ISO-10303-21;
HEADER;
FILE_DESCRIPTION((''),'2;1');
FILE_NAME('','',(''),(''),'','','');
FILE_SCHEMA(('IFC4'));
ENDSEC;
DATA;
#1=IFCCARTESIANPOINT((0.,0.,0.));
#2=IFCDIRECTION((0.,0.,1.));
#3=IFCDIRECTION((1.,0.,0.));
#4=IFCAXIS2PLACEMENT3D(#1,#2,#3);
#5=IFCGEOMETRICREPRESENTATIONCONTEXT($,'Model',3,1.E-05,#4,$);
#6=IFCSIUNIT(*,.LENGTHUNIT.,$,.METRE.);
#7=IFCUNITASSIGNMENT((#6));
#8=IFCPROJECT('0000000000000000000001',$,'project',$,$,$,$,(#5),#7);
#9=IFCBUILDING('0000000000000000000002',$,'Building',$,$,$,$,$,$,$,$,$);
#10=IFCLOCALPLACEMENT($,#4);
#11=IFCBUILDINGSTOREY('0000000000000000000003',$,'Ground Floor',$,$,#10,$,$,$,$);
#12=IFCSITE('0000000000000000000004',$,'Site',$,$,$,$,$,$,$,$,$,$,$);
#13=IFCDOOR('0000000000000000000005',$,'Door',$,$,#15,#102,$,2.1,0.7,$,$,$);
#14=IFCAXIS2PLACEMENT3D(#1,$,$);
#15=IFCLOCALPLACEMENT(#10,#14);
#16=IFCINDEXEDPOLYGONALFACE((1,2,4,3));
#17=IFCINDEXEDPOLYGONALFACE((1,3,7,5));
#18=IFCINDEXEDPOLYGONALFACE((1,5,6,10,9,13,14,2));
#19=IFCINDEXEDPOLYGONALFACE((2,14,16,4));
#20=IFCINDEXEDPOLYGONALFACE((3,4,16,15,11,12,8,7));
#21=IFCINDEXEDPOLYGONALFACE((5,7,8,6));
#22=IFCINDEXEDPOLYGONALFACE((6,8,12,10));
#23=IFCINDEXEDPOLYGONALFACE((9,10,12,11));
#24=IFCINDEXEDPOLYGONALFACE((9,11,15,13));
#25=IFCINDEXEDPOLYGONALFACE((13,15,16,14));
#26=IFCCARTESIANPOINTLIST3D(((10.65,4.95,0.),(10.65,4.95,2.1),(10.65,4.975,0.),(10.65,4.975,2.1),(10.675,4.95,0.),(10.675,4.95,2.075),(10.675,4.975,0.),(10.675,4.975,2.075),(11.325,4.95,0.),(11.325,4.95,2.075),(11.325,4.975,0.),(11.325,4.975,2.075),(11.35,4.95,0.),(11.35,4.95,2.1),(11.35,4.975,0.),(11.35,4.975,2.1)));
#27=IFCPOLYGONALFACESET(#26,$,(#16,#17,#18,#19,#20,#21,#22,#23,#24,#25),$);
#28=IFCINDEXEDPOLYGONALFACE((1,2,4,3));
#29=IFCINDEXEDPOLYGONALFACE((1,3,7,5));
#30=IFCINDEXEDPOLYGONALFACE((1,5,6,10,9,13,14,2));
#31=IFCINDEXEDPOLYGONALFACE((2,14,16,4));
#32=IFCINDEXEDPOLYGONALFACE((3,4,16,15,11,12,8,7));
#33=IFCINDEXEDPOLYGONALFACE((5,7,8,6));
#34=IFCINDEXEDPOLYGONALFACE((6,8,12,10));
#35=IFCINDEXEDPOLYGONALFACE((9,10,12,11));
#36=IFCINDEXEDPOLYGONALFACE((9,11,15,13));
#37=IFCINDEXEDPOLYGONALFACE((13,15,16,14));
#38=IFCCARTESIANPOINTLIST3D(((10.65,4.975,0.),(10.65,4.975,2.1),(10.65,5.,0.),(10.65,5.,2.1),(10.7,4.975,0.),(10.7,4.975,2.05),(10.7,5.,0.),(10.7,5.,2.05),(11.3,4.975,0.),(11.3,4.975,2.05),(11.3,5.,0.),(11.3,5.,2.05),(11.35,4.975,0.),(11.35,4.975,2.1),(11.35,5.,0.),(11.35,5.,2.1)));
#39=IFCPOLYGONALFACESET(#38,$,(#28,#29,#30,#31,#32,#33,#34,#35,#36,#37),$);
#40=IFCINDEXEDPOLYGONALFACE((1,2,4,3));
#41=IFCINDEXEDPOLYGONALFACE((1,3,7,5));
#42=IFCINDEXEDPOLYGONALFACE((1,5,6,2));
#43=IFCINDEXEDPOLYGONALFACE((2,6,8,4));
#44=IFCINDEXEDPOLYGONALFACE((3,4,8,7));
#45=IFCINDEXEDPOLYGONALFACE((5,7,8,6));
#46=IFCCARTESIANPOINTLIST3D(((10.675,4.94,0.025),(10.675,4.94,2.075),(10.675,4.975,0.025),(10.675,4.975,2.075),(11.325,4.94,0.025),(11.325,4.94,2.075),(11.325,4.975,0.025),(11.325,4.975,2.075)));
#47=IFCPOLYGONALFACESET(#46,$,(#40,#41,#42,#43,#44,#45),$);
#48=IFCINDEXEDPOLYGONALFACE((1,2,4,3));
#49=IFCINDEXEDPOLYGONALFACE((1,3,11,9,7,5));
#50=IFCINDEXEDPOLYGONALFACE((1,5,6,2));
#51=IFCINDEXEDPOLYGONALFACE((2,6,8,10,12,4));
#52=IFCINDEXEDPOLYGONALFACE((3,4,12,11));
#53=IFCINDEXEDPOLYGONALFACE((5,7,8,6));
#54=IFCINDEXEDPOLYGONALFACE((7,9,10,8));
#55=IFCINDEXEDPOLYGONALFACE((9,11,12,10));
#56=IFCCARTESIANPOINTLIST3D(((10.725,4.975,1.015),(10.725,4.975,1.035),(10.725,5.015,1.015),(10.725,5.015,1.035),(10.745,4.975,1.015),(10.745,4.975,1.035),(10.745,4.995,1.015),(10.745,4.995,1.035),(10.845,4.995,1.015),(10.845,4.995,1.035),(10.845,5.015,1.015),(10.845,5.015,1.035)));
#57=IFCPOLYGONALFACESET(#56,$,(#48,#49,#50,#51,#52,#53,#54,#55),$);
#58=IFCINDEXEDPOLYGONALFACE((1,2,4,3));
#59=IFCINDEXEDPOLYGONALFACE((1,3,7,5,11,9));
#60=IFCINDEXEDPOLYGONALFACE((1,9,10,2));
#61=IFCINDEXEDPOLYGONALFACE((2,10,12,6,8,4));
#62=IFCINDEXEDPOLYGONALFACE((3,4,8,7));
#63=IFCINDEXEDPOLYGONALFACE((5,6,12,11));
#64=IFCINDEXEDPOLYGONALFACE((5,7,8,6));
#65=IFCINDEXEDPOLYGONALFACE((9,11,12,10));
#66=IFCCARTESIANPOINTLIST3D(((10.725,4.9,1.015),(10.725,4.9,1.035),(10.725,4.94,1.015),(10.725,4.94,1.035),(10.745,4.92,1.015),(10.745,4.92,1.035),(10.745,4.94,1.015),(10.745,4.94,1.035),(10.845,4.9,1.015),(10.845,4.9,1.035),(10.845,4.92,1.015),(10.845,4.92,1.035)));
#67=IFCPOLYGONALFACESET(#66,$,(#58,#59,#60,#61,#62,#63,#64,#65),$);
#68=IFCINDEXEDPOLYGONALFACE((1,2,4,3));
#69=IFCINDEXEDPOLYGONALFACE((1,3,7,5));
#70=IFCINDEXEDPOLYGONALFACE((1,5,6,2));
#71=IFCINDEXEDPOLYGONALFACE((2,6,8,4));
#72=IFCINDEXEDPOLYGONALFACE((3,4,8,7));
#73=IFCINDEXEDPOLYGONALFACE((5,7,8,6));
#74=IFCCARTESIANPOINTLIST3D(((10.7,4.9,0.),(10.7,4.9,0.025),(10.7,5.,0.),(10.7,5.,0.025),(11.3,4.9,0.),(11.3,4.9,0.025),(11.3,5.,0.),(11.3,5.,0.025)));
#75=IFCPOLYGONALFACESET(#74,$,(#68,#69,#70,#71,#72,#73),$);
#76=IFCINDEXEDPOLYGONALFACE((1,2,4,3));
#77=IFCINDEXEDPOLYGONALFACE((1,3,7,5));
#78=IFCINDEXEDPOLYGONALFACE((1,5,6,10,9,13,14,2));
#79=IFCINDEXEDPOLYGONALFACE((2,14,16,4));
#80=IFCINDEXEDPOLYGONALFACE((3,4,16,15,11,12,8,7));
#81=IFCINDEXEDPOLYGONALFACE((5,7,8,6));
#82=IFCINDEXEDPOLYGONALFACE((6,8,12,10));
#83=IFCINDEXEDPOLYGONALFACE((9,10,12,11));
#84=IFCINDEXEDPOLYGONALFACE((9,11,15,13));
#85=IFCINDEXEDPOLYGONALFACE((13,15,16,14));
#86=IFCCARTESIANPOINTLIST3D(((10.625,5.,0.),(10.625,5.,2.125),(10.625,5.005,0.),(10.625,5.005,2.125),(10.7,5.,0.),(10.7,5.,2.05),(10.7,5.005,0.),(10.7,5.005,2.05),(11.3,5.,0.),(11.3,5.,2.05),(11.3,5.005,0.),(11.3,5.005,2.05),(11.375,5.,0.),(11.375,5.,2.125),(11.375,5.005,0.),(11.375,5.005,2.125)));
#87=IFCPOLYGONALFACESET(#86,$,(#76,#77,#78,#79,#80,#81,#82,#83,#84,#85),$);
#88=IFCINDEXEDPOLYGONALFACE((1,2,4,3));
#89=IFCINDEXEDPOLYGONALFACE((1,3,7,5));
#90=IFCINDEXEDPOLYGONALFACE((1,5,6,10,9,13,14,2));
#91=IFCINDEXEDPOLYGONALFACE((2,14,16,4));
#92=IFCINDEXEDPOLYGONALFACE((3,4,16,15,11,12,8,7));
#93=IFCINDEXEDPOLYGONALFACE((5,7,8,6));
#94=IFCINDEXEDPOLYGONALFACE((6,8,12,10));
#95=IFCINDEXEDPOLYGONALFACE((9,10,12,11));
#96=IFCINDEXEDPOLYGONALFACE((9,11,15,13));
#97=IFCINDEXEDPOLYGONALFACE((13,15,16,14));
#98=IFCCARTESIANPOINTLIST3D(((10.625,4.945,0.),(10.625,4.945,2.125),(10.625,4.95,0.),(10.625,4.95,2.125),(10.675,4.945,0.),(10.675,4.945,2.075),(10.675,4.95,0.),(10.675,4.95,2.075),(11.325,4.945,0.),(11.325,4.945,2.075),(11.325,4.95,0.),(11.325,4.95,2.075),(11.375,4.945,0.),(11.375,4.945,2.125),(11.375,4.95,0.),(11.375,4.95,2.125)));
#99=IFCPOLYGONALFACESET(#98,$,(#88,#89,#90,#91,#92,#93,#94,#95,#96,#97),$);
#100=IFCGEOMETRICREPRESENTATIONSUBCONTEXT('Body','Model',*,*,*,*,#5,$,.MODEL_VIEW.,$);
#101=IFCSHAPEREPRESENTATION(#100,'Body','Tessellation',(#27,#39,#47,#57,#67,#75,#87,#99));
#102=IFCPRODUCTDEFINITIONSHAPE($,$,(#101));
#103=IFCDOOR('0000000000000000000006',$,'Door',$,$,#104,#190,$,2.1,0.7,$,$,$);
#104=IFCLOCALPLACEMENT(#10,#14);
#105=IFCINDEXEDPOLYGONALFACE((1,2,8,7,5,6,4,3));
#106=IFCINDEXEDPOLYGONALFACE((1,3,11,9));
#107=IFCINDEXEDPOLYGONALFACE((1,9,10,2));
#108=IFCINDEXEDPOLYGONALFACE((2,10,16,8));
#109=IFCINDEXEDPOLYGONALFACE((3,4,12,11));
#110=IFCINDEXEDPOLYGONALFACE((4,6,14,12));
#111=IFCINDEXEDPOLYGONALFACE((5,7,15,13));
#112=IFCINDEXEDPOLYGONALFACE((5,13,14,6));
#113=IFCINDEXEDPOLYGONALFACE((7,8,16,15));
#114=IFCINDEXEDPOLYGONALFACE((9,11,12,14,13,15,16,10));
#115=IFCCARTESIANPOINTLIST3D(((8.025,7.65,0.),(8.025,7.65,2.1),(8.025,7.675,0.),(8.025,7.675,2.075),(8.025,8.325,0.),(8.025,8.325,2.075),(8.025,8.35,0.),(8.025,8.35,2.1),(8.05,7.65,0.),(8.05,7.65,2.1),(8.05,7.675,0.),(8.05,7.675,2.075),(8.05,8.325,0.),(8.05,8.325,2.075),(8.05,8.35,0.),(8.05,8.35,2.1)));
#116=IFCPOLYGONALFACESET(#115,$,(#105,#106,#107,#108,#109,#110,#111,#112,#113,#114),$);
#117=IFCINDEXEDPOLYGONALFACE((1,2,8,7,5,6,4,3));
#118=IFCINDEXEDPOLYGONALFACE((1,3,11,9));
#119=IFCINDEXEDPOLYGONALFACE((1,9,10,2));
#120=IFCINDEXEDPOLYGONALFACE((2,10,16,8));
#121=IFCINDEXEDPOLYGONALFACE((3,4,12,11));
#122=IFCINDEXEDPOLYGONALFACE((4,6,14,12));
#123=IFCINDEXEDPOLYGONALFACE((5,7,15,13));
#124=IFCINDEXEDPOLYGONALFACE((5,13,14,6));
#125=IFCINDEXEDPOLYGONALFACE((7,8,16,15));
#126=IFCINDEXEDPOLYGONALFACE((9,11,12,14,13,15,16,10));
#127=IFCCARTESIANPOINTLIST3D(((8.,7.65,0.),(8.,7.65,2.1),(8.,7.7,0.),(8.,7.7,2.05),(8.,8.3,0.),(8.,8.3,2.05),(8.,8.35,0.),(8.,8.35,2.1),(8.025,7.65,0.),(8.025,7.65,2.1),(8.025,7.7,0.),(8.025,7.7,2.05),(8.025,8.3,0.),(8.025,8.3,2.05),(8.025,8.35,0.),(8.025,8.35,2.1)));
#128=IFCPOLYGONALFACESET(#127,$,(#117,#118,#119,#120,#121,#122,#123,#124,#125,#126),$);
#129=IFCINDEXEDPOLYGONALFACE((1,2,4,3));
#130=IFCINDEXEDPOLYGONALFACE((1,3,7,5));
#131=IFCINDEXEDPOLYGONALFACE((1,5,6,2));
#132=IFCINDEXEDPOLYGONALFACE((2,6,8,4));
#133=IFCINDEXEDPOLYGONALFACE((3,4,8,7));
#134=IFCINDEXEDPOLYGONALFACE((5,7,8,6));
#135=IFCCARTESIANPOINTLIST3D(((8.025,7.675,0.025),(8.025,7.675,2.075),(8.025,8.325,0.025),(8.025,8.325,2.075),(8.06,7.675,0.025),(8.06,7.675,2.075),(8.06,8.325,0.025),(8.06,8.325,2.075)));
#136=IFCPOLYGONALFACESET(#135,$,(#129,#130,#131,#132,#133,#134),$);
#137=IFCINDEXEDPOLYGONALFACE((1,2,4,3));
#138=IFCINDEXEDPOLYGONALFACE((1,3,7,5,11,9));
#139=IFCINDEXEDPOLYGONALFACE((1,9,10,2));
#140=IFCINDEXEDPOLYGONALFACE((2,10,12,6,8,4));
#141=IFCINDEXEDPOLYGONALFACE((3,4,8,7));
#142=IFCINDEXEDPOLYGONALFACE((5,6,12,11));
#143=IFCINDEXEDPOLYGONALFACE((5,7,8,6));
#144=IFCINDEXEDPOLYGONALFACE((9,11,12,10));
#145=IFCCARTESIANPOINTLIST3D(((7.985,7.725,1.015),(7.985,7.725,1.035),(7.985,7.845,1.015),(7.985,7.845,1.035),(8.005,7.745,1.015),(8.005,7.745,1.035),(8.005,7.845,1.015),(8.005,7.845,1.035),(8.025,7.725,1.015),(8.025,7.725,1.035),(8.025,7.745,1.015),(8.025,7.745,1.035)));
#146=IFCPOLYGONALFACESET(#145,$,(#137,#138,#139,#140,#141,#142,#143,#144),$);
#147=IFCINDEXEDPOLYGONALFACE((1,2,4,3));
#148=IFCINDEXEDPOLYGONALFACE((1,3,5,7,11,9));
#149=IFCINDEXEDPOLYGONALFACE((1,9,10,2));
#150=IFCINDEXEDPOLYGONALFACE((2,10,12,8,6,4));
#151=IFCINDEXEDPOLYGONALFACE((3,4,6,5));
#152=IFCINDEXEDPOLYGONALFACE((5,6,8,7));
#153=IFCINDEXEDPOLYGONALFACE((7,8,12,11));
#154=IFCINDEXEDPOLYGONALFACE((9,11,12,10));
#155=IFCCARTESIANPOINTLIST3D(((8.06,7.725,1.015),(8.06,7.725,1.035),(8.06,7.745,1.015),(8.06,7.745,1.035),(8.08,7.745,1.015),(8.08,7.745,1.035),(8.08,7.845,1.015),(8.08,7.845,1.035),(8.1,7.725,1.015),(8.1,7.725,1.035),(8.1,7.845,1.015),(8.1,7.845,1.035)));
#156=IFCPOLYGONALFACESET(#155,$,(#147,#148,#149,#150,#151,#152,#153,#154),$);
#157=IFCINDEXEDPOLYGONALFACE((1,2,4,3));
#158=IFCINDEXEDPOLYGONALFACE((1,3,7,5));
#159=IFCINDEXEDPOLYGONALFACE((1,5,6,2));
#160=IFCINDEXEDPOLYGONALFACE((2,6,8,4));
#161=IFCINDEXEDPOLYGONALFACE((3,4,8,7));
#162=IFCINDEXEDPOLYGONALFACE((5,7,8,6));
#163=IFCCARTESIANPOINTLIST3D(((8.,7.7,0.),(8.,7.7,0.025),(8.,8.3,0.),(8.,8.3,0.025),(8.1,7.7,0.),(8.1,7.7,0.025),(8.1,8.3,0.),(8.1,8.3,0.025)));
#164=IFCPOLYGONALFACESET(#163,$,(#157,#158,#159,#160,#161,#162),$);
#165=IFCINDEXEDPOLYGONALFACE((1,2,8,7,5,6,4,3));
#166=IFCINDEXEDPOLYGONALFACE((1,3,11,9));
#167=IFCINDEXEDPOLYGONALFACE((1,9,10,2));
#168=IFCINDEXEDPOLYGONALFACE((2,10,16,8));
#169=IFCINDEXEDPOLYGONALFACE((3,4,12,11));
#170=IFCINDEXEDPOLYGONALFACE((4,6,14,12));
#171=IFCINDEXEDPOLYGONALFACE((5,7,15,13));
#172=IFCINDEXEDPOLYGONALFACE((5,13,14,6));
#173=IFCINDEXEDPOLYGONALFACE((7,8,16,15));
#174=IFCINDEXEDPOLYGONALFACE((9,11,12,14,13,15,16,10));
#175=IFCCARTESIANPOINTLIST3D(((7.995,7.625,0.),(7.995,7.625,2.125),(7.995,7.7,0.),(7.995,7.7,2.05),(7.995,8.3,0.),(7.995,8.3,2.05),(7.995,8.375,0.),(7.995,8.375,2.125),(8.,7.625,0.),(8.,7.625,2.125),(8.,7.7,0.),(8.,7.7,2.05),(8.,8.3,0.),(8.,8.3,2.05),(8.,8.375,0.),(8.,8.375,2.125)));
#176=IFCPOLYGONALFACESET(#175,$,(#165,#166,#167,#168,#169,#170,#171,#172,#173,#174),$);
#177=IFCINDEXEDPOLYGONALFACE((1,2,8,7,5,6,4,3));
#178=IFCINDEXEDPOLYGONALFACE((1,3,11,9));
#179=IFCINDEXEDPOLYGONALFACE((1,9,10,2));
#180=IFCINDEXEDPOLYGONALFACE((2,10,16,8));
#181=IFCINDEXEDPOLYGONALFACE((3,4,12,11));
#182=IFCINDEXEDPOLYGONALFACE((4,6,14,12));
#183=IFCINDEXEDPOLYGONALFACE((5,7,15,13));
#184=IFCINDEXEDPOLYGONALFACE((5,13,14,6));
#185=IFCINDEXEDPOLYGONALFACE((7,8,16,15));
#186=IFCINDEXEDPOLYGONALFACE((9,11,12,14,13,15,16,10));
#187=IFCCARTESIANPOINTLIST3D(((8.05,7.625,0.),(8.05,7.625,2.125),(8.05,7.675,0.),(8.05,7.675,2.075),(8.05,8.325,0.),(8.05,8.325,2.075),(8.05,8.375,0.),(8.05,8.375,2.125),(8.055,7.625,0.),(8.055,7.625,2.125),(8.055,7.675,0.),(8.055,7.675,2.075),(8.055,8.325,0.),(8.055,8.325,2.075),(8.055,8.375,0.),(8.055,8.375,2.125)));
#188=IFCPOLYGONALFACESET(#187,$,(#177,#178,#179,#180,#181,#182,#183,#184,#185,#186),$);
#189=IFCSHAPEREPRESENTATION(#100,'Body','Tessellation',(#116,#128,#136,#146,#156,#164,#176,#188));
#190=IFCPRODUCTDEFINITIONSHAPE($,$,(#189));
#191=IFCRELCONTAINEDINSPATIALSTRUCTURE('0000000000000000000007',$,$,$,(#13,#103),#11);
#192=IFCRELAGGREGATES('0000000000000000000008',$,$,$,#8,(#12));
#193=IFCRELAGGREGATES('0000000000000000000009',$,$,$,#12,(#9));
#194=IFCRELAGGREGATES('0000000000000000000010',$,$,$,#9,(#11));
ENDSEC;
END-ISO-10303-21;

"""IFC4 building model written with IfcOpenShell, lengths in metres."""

from ifc_helpers import new_model, si_unit, frame, origin_with_axes, place, context, subcontext, project, spatial, line, indexed_curve, outline, extrude, element, save


model = new_model("IFC4")

# Units and contexts
model_context = context("Model", 3, precision=1e-05, world=origin_with_axes())
body_context = subcontext(model_context, "Body", "Model", "MODEL_VIEW")
ifc_project = project(units=[si_unit("LENGTHUNIT", "METRE")], contexts=[model_context])

# Site, building, storey
site = spatial("IfcSite", under=ifc_project, Name="Site")
building = spatial("IfcBuilding", under=site, Name="Building")
storey_placement = place(None, origin_with_axes())
storey = spatial("IfcBuildingStorey", under=building, at=storey_placement, Name="Ground Floor")

# Doors
door_1_placement = place(storey_placement, frame((11.35, 5.0, 0.0), z_axis=(0.0, 0.0, 1.0), x_axis=(-1.0, 0.0, 0.0)))
element("IfcDoor", 1, at=door_1_placement, inside=storey, Name="Door", OverallHeight=2.1, OverallWidth=0.7, context=body_context, shape_type="SweptSolid", body=[
    extrude(outline(indexed_curve([(0.0, 0.0), (0.0, 2.1), (0.7, 2.1), (0.7, 0.0), (0.675, 0.0), (0.675, 2.075), (0.025, 2.075), (0.025, 0.0)], segments=[line(1, 2, 3, 4, 5, 6, 7, 8, 1)])), frame((0.0, 0.025, 0.0), z_axis=(0.0, -1.0, 0.0), x_axis=(1.0, 0.0, 0.0)), (0.0, 0.0, -1.0), 0.025),
    extrude(outline(indexed_curve([(0.0, 0.0), (0.0, 2.1), (0.7, 2.1), (0.7, 0.0), (0.65, 0.0), (0.65, 2.05), (0.05, 2.05), (0.05, 0.0)], segments=[line(1, 2, 3, 4, 5, 6, 7, 8, 1)])), frame((0.0, 0.0, 0.0), z_axis=(0.0, -1.0, 0.0), x_axis=(1.0, 0.0, 0.0)), (0.0, 0.0, -1.0), 0.025),
    extrude(outline(indexed_curve([(0.0, 0.0), (0.65, 0.0), (0.65, 0.035), (0.0, 0.035)], segments=[line(1, 2, 3, 4, 1)])), frame((0.025, 0.025, 0.025), z_axis=(0.0, 0.0, 1.0), x_axis=(1.0, 0.0, 0.0)), (0.0, 0.0, 1.0), 2.05),
    extrude(outline(indexed_curve([(0.0, 0.0), (0.0, -0.04), (-0.12, -0.04), (-0.12, -0.02), (-0.02, -0.02), (-0.02, 0.0)], segments=[line(1, 2, 3, 4, 5, 6, 1)])), frame((0.625, 0.025, 1.015), z_axis=(0.0, 0.0, 1.0), x_axis=(1.0, 0.0, 0.0)), (0.0, 0.0, 1.0), 0.02),
    extrude(outline(indexed_curve([(0.0, 0.0), (0.0, 0.04), (-0.12, 0.04), (-0.12, 0.02), (-0.02, 0.02), (-0.02, 0.0)], segments=[line(1, 2, 3, 4, 5, 6, 1)])), frame((0.625, 0.06, 1.015), z_axis=(0.0, 0.0, 1.0), x_axis=(1.0, 0.0, 0.0)), (0.0, 0.0, 1.0), 0.02),
    extrude(outline(indexed_curve([(0.0, 0.0), (0.6, 0.0), (0.6, 0.1), (0.0, 0.1)], segments=[line(1, 2, 3, 4, 1)])), frame((0.05, 0.0, 0.0), z_axis=(0.0, 0.0, 1.0), x_axis=(1.0, 0.0, 0.0)), (0.0, 0.0, 1.0), 0.025),
    extrude(outline(indexed_curve([(0.0, 0.0), (0.0, 2.125), (0.75, 2.125), (0.75, 0.0), (0.675, 0.0), (0.675, 2.05), (0.075, 2.05), (0.075, 0.0)], segments=[line(1, 2, 3, 4, 5, 6, 7, 8, 1)])), frame((-0.025, -0.005, 0.0), z_axis=(0.0, -1.0, 0.0), x_axis=(1.0, 0.0, 0.0)), (0.0, 0.0, -1.0), 0.005),
    extrude(outline(indexed_curve([(0.0, 0.0), (0.0, 2.125), (0.75, 2.125), (0.75, 0.0), (0.7, 0.0), (0.7, 2.075), (0.05, 2.075), (0.05, 0.0)], segments=[line(1, 2, 3, 4, 5, 6, 7, 8, 1)])), frame((-0.025, 0.05, 0.0), z_axis=(0.0, -1.0, 0.0), x_axis=(1.0, 0.0, 0.0)), (0.0, 0.0, -1.0), 0.005),
])
door_2_placement = place(storey_placement, frame((8.0, 8.35, 0.0), z_axis=(0.0, 0.0, 1.0), x_axis=(0.0, -1.0, 0.0)))
element("IfcDoor", 2, at=door_2_placement, inside=storey, Name="Door", OverallHeight=2.1, OverallWidth=0.7, context=body_context, shape_type="SweptSolid", body=[
    extrude(outline(indexed_curve([(0.0, 0.0), (0.0, 2.1), (0.7, 2.1), (0.7, 0.0), (0.675, 0.0), (0.675, 2.075), (0.025, 2.075), (0.025, 0.0)], segments=[line(1, 2, 3, 4, 5, 6, 7, 8, 1)])), frame((0.0, 0.025, 0.0), z_axis=(0.0, -1.0, 0.0), x_axis=(1.0, 0.0, 0.0)), (0.0, 0.0, -1.0), 0.025),
    extrude(outline(indexed_curve([(0.0, 0.0), (0.0, 2.1), (0.7, 2.1), (0.7, 0.0), (0.65, 0.0), (0.65, 2.05), (0.05, 2.05), (0.05, 0.0)], segments=[line(1, 2, 3, 4, 5, 6, 7, 8, 1)])), frame((0.0, 0.0, 0.0), z_axis=(0.0, -1.0, 0.0), x_axis=(1.0, 0.0, 0.0)), (0.0, 0.0, -1.0), 0.025),
    extrude(outline(indexed_curve([(0.0, 0.0), (0.65, 0.0), (0.65, 0.035), (0.0, 0.035)], segments=[line(1, 2, 3, 4, 1)])), frame((0.025, 0.025, 0.025), z_axis=(0.0, 0.0, 1.0), x_axis=(1.0, 0.0, 0.0)), (0.0, 0.0, 1.0), 2.05),
    extrude(outline(indexed_curve([(0.0, 0.0), (0.0, -0.04), (-0.12, -0.04), (-0.12, -0.02), (-0.02, -0.02), (-0.02, 0.0)], segments=[line(1, 2, 3, 4, 5, 6, 1)])), frame((0.625, 0.025, 1.015), z_axis=(0.0, 0.0, 1.0), x_axis=(1.0, 0.0, 0.0)), (0.0, 0.0, 1.0), 0.02),
    extrude(outline(indexed_curve([(0.0, 0.0), (0.0, 0.04), (-0.12, 0.04), (-0.12, 0.02), (-0.02, 0.02), (-0.02, 0.0)], segments=[line(1, 2, 3, 4, 5, 6, 1)])), frame((0.625, 0.06, 1.015), z_axis=(0.0, 0.0, 1.0), x_axis=(1.0, 0.0, 0.0)), (0.0, 0.0, 1.0), 0.02),
    extrude(outline(indexed_curve([(0.0, 0.0), (0.6, 0.0), (0.6, 0.1), (0.0, 0.1)], segments=[line(1, 2, 3, 4, 1)])), frame((0.05, 0.0, 0.0), z_axis=(0.0, 0.0, 1.0), x_axis=(1.0, 0.0, 0.0)), (0.0, 0.0, 1.0), 0.025),
    extrude(outline(indexed_curve([(0.0, 0.0), (0.0, 2.125), (0.75, 2.125), (0.75, 0.0), (0.675, 0.0), (0.675, 2.05), (0.075, 2.05), (0.075, 0.0)], segments=[line(1, 2, 3, 4, 5, 6, 7, 8, 1)])), frame((-0.025, -0.005, 0.0), z_axis=(0.0, -1.0, 0.0), x_axis=(1.0, 0.0, 0.0)), (0.0, 0.0, -1.0), 0.005),
    extrude(outline(indexed_curve([(0.0, 0.0), (0.0, 2.125), (0.75, 2.125), (0.75, 0.0), (0.7, 0.0), (0.7, 2.075), (0.05, 2.075), (0.05, 0.0)], segments=[line(1, 2, 3, 4, 5, 6, 7, 8, 1)])), frame((-0.025, 0.05, 0.0), z_axis=(0.0, -1.0, 0.0), x_axis=(1.0, 0.0, 0.0)), (0.0, 0.0, -1.0), 0.005),
])

save(model, "model.ifc")
